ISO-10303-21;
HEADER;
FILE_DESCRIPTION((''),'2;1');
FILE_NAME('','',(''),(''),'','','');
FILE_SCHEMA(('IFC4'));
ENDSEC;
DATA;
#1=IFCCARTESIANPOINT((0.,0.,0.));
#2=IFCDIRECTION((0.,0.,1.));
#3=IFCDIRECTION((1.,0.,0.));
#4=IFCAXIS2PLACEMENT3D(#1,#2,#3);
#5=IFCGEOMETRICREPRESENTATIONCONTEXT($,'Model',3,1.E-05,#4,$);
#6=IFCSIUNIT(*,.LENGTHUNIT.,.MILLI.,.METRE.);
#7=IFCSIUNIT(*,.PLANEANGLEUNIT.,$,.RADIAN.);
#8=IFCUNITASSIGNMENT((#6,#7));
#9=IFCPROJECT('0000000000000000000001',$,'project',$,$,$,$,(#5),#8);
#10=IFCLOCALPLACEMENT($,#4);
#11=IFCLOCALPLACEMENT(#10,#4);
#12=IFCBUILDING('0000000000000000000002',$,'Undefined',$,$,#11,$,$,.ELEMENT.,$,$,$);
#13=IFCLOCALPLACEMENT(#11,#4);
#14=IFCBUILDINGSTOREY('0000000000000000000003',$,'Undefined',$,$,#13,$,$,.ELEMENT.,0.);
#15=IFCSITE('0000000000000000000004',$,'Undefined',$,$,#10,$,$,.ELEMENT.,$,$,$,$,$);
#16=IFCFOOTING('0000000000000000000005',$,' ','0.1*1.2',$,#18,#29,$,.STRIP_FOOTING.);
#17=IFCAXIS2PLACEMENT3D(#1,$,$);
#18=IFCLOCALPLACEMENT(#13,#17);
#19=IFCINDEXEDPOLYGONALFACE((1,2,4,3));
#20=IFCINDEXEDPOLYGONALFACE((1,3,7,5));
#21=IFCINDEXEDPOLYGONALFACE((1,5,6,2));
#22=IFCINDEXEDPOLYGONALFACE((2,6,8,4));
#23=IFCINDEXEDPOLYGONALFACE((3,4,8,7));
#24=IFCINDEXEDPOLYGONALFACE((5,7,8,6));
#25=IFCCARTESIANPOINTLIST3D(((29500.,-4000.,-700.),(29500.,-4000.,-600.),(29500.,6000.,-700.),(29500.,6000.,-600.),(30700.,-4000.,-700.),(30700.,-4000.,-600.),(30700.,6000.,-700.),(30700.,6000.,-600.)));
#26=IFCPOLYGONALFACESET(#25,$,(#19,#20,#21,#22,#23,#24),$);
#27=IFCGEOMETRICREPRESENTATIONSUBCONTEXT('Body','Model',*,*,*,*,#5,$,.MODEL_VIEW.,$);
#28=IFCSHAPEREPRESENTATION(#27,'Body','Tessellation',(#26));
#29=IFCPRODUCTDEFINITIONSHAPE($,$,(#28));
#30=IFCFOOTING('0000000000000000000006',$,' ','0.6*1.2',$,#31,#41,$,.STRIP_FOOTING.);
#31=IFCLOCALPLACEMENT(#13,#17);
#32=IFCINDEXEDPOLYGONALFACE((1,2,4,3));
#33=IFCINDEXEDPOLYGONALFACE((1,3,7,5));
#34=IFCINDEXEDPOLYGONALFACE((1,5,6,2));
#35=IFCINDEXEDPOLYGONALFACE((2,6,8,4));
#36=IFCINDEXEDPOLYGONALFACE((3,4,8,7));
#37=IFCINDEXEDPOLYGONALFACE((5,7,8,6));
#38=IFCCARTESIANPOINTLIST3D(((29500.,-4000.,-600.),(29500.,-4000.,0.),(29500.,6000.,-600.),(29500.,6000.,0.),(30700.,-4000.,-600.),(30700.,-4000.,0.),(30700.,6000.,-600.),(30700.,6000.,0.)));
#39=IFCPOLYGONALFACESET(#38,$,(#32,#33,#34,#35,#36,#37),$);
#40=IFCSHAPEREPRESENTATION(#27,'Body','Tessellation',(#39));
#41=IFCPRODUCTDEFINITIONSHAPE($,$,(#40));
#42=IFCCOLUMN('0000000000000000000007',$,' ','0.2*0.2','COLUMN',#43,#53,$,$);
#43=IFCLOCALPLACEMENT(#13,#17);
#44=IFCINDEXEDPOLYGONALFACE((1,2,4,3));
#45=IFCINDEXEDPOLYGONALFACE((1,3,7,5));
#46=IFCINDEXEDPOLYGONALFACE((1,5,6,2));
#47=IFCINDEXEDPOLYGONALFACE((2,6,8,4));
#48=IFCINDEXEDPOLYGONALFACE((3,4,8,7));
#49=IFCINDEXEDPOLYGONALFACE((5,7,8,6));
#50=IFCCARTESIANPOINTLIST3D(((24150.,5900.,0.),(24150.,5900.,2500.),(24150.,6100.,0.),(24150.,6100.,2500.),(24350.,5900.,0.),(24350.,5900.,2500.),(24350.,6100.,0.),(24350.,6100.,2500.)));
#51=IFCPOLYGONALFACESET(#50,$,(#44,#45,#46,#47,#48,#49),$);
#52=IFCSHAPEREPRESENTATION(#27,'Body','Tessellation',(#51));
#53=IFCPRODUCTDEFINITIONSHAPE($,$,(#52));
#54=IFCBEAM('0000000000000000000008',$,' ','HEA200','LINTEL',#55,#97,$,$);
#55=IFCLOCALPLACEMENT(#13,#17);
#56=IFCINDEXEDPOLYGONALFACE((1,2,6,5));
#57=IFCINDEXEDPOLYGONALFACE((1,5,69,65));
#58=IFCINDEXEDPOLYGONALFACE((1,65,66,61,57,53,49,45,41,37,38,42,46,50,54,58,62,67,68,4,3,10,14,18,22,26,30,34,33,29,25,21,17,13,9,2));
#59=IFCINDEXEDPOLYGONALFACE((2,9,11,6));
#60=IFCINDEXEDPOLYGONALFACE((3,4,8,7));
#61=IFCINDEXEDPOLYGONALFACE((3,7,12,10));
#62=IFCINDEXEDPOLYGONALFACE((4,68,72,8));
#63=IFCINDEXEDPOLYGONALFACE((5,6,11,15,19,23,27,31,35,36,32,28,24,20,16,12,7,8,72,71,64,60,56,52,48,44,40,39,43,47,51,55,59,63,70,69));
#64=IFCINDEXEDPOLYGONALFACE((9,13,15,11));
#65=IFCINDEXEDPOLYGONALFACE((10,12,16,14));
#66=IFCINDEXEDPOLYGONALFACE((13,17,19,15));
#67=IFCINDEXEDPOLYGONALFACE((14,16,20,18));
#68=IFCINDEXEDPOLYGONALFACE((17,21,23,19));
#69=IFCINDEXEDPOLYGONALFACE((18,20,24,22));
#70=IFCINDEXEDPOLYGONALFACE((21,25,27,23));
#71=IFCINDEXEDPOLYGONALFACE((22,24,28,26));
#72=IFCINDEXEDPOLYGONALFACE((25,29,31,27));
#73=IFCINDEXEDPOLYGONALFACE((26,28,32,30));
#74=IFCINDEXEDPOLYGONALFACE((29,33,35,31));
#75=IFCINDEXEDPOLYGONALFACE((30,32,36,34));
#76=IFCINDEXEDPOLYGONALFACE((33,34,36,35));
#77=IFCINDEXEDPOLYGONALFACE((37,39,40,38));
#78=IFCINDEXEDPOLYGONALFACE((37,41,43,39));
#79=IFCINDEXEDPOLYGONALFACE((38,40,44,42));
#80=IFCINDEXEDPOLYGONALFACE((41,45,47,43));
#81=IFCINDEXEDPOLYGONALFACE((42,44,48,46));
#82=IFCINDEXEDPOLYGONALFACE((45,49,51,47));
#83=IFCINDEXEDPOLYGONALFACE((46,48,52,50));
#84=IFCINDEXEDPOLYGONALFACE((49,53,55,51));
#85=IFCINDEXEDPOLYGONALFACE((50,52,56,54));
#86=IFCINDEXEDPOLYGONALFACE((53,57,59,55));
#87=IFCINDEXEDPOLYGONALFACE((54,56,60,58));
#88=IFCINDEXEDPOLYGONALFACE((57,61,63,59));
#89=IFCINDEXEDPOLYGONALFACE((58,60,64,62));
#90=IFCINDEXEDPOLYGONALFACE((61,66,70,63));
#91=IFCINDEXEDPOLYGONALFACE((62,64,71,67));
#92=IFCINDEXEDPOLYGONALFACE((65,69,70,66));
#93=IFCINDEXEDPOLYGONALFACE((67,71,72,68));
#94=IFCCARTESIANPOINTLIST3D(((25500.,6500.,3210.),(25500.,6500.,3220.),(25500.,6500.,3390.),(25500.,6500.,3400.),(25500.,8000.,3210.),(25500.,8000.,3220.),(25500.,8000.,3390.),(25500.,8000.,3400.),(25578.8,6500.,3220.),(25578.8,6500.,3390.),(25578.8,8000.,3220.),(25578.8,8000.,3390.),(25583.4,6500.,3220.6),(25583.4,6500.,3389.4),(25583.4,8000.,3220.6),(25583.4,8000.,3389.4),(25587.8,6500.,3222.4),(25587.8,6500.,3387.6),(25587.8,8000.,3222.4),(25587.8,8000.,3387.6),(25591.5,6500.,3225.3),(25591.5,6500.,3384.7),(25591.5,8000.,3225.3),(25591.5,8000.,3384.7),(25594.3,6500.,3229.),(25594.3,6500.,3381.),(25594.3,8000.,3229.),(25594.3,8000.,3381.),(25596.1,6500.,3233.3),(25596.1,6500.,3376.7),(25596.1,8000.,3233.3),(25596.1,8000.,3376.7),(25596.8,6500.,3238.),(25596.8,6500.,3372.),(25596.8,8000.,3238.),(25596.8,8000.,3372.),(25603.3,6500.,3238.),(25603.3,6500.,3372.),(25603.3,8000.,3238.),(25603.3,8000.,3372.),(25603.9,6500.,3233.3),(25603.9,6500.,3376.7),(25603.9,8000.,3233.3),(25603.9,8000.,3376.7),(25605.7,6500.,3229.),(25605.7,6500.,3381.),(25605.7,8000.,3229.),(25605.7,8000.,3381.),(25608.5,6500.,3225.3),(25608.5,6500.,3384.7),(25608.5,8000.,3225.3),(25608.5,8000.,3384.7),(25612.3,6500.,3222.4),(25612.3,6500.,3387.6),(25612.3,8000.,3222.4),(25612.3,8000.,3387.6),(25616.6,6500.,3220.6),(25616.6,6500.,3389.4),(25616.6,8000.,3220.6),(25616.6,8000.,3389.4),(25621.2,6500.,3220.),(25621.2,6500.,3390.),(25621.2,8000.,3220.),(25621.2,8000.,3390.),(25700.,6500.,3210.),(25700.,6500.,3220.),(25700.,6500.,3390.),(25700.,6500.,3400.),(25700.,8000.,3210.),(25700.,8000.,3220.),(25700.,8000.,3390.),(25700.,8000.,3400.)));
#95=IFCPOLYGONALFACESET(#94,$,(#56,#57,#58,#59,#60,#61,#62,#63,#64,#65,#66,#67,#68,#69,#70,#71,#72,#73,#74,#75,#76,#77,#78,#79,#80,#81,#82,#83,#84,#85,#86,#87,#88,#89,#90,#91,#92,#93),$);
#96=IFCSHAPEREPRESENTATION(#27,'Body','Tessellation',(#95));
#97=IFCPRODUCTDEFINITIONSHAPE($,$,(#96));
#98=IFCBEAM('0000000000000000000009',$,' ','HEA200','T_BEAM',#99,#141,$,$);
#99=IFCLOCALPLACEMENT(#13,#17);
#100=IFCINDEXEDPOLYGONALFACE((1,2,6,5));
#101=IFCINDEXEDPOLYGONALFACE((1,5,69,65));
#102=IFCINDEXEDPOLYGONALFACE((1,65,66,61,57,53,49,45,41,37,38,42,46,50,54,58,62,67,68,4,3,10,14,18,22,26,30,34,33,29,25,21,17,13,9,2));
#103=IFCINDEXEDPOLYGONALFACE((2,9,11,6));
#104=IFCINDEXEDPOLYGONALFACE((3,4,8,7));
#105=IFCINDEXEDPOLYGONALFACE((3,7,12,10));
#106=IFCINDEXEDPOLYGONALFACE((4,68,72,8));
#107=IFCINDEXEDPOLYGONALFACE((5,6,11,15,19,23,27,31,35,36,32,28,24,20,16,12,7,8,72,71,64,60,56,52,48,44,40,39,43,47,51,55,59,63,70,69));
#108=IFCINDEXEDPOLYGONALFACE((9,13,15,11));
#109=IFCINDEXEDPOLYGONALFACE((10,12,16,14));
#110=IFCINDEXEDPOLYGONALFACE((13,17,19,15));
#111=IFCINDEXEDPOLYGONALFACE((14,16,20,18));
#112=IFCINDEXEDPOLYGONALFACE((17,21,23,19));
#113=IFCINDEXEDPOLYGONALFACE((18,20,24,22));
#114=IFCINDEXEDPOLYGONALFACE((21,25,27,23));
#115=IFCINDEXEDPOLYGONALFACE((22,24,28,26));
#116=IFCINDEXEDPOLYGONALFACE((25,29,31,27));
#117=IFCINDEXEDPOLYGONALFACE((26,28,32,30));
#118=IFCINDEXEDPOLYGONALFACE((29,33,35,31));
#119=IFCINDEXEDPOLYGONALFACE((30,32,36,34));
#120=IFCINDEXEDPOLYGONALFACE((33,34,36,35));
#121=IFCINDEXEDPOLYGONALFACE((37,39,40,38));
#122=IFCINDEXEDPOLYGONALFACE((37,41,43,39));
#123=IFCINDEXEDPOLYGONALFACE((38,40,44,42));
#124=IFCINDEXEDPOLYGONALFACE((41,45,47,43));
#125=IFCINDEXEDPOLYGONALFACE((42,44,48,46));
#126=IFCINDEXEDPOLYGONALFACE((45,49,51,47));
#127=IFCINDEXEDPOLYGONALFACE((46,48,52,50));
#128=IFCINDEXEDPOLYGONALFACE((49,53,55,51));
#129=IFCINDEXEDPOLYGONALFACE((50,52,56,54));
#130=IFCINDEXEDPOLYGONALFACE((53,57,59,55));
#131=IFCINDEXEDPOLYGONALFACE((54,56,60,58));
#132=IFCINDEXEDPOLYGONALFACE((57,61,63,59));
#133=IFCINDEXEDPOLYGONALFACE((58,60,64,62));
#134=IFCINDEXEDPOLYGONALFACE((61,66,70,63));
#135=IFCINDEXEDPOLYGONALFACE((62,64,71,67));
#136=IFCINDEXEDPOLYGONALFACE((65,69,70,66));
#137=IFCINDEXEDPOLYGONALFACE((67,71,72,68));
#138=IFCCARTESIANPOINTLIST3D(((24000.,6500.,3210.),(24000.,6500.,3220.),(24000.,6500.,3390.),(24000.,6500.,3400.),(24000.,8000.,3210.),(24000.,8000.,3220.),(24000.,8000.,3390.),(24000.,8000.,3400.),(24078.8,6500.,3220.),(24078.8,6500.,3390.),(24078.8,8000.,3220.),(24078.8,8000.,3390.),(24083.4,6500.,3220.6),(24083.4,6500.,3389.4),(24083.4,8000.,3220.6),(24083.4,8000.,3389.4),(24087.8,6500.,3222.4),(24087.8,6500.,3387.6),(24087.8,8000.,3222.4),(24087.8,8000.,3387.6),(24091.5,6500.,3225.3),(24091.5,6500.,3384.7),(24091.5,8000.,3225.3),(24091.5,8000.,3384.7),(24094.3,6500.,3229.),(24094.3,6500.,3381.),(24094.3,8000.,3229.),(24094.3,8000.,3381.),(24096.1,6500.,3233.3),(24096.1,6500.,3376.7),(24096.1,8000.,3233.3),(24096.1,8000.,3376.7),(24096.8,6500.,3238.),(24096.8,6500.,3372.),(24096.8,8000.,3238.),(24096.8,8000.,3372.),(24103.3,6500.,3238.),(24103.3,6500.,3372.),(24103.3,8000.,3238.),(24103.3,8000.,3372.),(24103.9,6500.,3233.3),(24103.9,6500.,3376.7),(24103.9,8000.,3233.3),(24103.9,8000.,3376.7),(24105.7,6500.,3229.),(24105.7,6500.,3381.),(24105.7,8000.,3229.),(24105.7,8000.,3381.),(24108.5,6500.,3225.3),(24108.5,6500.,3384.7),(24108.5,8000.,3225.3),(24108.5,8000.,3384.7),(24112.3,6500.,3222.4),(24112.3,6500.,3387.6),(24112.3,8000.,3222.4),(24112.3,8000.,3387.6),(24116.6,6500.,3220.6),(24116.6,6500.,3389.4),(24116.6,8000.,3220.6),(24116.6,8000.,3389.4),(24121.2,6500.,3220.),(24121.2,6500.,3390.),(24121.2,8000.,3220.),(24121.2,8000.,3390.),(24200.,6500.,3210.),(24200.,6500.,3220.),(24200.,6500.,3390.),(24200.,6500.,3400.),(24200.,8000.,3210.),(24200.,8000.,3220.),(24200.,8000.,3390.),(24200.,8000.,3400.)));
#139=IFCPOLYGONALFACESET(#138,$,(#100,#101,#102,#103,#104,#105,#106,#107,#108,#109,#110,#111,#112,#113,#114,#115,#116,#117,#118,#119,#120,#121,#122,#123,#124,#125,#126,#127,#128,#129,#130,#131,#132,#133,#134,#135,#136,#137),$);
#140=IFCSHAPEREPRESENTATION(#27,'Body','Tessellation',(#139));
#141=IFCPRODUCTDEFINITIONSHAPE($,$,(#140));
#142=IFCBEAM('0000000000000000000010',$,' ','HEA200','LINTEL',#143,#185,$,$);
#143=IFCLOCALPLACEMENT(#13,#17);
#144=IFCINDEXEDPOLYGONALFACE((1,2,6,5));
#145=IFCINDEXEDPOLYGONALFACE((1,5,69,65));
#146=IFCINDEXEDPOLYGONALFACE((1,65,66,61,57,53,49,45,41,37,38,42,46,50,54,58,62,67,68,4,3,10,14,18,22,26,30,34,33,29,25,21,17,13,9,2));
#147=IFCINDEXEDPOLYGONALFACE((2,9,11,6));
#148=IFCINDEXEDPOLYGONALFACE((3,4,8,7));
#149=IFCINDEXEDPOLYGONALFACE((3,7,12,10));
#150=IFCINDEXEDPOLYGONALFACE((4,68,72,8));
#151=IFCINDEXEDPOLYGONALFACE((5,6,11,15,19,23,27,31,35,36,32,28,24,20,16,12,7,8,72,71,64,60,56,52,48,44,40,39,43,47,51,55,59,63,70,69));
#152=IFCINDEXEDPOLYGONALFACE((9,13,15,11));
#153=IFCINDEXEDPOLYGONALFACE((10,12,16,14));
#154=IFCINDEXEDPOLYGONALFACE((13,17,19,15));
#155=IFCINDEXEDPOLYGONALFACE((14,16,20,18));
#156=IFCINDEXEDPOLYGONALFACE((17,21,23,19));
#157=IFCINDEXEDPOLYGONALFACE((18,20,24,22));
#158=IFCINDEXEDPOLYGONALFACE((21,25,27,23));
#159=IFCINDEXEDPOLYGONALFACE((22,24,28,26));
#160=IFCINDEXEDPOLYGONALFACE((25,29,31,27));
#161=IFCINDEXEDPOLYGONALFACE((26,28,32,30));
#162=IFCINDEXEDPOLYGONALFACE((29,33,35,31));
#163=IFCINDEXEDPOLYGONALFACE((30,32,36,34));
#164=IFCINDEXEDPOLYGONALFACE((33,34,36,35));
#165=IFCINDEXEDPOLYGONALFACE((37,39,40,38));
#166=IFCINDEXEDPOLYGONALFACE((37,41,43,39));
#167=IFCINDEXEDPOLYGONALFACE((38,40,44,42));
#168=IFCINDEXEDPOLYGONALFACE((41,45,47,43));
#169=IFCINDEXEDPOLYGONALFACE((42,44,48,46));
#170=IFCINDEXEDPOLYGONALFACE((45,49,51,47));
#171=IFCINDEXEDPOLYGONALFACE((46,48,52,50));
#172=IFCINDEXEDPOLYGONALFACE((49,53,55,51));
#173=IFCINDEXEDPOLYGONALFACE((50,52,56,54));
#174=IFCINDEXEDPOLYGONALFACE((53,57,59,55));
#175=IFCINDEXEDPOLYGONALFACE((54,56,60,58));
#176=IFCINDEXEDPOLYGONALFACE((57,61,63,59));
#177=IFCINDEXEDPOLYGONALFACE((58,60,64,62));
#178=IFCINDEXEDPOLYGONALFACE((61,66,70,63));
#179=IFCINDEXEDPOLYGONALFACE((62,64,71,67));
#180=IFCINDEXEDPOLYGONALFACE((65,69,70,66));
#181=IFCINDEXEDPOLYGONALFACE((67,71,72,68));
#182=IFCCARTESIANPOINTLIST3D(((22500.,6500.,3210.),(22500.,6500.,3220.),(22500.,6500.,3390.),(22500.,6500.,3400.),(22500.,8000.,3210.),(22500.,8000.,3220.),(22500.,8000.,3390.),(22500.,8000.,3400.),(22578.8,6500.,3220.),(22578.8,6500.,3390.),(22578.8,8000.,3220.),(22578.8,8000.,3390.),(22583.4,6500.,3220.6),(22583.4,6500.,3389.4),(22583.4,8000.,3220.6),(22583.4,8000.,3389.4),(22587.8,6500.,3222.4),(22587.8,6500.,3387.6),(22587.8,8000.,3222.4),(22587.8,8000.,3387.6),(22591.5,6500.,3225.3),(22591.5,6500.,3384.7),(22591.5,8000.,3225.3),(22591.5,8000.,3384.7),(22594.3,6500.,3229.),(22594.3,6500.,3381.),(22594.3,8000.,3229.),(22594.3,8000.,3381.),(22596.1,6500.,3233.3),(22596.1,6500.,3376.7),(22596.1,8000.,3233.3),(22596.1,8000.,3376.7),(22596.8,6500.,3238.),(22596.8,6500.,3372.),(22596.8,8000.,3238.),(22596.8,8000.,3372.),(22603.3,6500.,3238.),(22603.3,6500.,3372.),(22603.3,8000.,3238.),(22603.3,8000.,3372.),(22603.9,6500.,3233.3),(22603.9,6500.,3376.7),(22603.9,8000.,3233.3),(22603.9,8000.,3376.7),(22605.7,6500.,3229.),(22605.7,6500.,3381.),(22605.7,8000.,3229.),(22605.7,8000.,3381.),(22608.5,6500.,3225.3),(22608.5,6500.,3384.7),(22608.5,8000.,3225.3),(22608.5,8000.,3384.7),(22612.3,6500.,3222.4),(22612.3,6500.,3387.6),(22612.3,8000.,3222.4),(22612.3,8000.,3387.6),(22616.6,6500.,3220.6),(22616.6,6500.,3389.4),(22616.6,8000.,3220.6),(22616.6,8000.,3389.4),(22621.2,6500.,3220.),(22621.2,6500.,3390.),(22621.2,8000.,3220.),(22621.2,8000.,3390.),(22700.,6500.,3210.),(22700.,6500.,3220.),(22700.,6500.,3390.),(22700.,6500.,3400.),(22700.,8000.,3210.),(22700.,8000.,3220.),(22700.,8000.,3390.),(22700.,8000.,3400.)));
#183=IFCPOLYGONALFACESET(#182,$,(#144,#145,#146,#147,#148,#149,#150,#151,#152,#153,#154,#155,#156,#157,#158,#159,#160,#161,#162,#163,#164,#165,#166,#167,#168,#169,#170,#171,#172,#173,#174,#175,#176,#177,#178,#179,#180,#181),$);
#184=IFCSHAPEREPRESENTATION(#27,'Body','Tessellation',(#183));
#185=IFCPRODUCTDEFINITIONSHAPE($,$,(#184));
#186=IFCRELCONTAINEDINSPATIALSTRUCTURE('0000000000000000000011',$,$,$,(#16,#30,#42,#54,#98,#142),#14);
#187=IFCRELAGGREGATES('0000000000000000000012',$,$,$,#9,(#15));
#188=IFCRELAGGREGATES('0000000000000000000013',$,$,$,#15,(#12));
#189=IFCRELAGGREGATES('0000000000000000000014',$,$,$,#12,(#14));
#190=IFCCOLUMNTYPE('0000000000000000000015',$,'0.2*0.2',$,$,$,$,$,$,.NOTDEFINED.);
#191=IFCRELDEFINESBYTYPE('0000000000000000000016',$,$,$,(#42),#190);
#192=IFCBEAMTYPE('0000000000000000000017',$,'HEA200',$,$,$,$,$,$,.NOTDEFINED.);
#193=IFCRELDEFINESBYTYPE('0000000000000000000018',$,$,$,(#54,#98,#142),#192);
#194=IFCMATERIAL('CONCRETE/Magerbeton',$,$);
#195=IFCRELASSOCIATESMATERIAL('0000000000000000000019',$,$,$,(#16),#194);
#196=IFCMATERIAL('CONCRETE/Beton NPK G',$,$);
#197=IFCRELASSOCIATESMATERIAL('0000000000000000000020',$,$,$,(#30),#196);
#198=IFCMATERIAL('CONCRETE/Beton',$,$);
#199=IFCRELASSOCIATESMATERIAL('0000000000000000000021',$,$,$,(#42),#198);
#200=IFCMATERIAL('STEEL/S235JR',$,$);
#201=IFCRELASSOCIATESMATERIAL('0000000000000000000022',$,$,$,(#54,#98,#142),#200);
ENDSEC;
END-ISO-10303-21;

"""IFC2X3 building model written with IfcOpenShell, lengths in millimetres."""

from ifc_helpers import new_model, si_unit, frame, origin_with_axes, origin_2d_with_axis, place, context, subcontext, project, spatial, rectangle, i_section, extrude, material, type_object, element, save


model = new_model("IFC2X3")

# Units and contexts
model_context = context("Model", 3, precision=1e-05, world=origin_with_axes())
body_context = subcontext(model_context, "Body", "Model", "MODEL_VIEW")
ifc_project = project(units=[si_unit("LENGTHUNIT", "METRE", prefix="MILLI"), si_unit("PLANEANGLEUNIT", "RADIAN")], contexts=[model_context])

# Site, building, storey
site_placement = place(None, origin_with_axes())
site = spatial("IfcSite", under=ifc_project, at=site_placement, Name="Undefined", CompositionType="ELEMENT")
building_placement = place(site_placement, origin_with_axes())
building = spatial("IfcBuilding", under=site, at=building_placement, Name="Undefined", CompositionType="ELEMENT")
storey_placement = place(building_placement, origin_with_axes())
storey = spatial("IfcBuildingStorey", under=building, at=storey_placement, Name="Undefined", CompositionType="ELEMENT", Elevation=0.0)

# Footings
ifc_material_1 = material(Name="CONCRETE/Magerbeton")
footing_1_placement = place(storey_placement, frame((30100.0, 6000.0, -650.0), z_axis=(0.0, 0.0, 1.0), x_axis=(0.0, -1.0, 0.0)))
element("IfcFooting", 1, at=footing_1_placement, inside=storey, material=ifc_material_1, Name=" ", Description="0.1*1.2", PredefinedType="STRIP_FOOTING", context=body_context, shape_type="SweptSolid", body=[
    extrude(rectangle(XDim=1200.0, YDim=100.0, at=origin_2d_with_axis()), frame((10000.0, 0.0, 0.0), z_axis=(-1.0, 0.0, 0.0), x_axis=(0.0, -1.0, 0.0)), (0.0, 0.0, 1.0), 10000.0),
])
ifc_material_2 = material(Name="CONCRETE/Beton NPK G")
footing_2_placement = place(storey_placement, frame((30100.0, 6000.0, -300.0), z_axis=(0.0, 0.0, 1.0), x_axis=(0.0, -1.0, 0.0)))
element("IfcFooting", 2, at=footing_2_placement, inside=storey, material=ifc_material_2, Name=" ", Description="0.6*1.2", PredefinedType="STRIP_FOOTING", context=body_context, shape_type="SweptSolid", body=[
    extrude(rectangle(XDim=1200.0, YDim=600.0, at=origin_2d_with_axis()), frame((10000.0, 0.0, 0.0), z_axis=(-1.0, 0.0, 0.0), x_axis=(0.0, -1.0, 0.0)), (0.0, 0.0, 1.0), 10000.0),
])

# Column
ifc_material_3 = material(Name="CONCRETE/Beton")
column_type = type_object("IfcColumnType", Name="0.2*0.2", PredefinedType="NOTDEFINED")
column_placement = place(storey_placement, frame((24250.0, 6000.0, 0.0), z_axis=(0.0, 0.0, 1.0), x_axis=(0.0, 1.0, 0.0)))
element("IfcColumn", 3, at=column_placement, inside=storey, type_object=column_type, material=ifc_material_3, Name=" ", Description="0.2*0.2", ObjectType="COLUMN", context=body_context, shape_type="SweptSolid", body=[
    extrude(rectangle(XDim=200.0, YDim=200.0, at=origin_2d_with_axis()), frame((0.0, 0.0, 2500.0), z_axis=(0.0, 0.0, -1.0), x_axis=(0.0, 1.0, 0.0)), (0.0, 0.0, 1.0), 2500.0),
])

# Beams
ifc_material_4 = material(Name="STEEL/S235JR")
beam_type_1 = type_object("IfcBeamType", Name="HEA200", PredefinedType="NOTDEFINED")
beam_1_placement = place(storey_placement, frame((25600.0, 6500.0, 3305.0), z_axis=(0.0, 0.0, 1.0), x_axis=(0.0, 1.0, 0.0)))
element("IfcBeam", 4, at=beam_1_placement, inside=storey, type_object=beam_type_1, material=ifc_material_4, Name=" ", Description="HEA200", ObjectType="LINTEL", context=body_context, shape_type="SweptSolid", body=[
    extrude(i_section(OverallWidth=200.0, OverallDepth=190.0, WebThickness=6.5, FlangeThickness=10.0, FilletRadius=18.0, at=origin_2d_with_axis()), frame((1500.0, 0.0, 0.0), z_axis=(-1.0, 0.0, 0.0), x_axis=(0.0, -1.0, 0.0)), (0.0, 0.0, 1.0), 1500.0),
])
beam_2_placement = place(storey_placement, frame((24100.0, 6500.0, 3305.0), z_axis=(0.0, 0.0, 1.0), x_axis=(0.0, 1.0, 0.0)))
element("IfcBeam", 5, at=beam_2_placement, inside=storey, type_object=beam_type_1, material=ifc_material_4, Name=" ", Description="HEA200", ObjectType="T_BEAM", context=body_context, shape_type="SweptSolid", body=[
    extrude(i_section(OverallWidth=200.0, OverallDepth=190.0, WebThickness=6.5, FlangeThickness=10.0, FilletRadius=18.0, at=origin_2d_with_axis()), frame((1500.0, 0.0, 0.0), z_axis=(-1.0, 0.0, 0.0), x_axis=(0.0, -1.0, 0.0)), (0.0, 0.0, 1.0), 1500.0),
])
beam_3_placement = place(storey_placement, frame((22600.0, 6500.0, 3305.0), z_axis=(0.0, 0.0, 1.0), x_axis=(0.0, 1.0, 0.0)))
element("IfcBeam", 6, at=beam_3_placement, inside=storey, type_object=beam_type_1, material=ifc_material_4, Name=" ", Description="HEA200", ObjectType="LINTEL", context=body_context, shape_type="SweptSolid", body=[
    extrude(i_section(OverallWidth=200.0, OverallDepth=190.0, WebThickness=6.5, FlangeThickness=10.0, FilletRadius=18.0, at=origin_2d_with_axis()), frame((1500.0, 0.0, 0.0), z_axis=(-1.0, 0.0, 0.0), x_axis=(0.0, -1.0, 0.0)), (0.0, 0.0, 1.0), 1500.0),
])

save(model, "model.ifc")
